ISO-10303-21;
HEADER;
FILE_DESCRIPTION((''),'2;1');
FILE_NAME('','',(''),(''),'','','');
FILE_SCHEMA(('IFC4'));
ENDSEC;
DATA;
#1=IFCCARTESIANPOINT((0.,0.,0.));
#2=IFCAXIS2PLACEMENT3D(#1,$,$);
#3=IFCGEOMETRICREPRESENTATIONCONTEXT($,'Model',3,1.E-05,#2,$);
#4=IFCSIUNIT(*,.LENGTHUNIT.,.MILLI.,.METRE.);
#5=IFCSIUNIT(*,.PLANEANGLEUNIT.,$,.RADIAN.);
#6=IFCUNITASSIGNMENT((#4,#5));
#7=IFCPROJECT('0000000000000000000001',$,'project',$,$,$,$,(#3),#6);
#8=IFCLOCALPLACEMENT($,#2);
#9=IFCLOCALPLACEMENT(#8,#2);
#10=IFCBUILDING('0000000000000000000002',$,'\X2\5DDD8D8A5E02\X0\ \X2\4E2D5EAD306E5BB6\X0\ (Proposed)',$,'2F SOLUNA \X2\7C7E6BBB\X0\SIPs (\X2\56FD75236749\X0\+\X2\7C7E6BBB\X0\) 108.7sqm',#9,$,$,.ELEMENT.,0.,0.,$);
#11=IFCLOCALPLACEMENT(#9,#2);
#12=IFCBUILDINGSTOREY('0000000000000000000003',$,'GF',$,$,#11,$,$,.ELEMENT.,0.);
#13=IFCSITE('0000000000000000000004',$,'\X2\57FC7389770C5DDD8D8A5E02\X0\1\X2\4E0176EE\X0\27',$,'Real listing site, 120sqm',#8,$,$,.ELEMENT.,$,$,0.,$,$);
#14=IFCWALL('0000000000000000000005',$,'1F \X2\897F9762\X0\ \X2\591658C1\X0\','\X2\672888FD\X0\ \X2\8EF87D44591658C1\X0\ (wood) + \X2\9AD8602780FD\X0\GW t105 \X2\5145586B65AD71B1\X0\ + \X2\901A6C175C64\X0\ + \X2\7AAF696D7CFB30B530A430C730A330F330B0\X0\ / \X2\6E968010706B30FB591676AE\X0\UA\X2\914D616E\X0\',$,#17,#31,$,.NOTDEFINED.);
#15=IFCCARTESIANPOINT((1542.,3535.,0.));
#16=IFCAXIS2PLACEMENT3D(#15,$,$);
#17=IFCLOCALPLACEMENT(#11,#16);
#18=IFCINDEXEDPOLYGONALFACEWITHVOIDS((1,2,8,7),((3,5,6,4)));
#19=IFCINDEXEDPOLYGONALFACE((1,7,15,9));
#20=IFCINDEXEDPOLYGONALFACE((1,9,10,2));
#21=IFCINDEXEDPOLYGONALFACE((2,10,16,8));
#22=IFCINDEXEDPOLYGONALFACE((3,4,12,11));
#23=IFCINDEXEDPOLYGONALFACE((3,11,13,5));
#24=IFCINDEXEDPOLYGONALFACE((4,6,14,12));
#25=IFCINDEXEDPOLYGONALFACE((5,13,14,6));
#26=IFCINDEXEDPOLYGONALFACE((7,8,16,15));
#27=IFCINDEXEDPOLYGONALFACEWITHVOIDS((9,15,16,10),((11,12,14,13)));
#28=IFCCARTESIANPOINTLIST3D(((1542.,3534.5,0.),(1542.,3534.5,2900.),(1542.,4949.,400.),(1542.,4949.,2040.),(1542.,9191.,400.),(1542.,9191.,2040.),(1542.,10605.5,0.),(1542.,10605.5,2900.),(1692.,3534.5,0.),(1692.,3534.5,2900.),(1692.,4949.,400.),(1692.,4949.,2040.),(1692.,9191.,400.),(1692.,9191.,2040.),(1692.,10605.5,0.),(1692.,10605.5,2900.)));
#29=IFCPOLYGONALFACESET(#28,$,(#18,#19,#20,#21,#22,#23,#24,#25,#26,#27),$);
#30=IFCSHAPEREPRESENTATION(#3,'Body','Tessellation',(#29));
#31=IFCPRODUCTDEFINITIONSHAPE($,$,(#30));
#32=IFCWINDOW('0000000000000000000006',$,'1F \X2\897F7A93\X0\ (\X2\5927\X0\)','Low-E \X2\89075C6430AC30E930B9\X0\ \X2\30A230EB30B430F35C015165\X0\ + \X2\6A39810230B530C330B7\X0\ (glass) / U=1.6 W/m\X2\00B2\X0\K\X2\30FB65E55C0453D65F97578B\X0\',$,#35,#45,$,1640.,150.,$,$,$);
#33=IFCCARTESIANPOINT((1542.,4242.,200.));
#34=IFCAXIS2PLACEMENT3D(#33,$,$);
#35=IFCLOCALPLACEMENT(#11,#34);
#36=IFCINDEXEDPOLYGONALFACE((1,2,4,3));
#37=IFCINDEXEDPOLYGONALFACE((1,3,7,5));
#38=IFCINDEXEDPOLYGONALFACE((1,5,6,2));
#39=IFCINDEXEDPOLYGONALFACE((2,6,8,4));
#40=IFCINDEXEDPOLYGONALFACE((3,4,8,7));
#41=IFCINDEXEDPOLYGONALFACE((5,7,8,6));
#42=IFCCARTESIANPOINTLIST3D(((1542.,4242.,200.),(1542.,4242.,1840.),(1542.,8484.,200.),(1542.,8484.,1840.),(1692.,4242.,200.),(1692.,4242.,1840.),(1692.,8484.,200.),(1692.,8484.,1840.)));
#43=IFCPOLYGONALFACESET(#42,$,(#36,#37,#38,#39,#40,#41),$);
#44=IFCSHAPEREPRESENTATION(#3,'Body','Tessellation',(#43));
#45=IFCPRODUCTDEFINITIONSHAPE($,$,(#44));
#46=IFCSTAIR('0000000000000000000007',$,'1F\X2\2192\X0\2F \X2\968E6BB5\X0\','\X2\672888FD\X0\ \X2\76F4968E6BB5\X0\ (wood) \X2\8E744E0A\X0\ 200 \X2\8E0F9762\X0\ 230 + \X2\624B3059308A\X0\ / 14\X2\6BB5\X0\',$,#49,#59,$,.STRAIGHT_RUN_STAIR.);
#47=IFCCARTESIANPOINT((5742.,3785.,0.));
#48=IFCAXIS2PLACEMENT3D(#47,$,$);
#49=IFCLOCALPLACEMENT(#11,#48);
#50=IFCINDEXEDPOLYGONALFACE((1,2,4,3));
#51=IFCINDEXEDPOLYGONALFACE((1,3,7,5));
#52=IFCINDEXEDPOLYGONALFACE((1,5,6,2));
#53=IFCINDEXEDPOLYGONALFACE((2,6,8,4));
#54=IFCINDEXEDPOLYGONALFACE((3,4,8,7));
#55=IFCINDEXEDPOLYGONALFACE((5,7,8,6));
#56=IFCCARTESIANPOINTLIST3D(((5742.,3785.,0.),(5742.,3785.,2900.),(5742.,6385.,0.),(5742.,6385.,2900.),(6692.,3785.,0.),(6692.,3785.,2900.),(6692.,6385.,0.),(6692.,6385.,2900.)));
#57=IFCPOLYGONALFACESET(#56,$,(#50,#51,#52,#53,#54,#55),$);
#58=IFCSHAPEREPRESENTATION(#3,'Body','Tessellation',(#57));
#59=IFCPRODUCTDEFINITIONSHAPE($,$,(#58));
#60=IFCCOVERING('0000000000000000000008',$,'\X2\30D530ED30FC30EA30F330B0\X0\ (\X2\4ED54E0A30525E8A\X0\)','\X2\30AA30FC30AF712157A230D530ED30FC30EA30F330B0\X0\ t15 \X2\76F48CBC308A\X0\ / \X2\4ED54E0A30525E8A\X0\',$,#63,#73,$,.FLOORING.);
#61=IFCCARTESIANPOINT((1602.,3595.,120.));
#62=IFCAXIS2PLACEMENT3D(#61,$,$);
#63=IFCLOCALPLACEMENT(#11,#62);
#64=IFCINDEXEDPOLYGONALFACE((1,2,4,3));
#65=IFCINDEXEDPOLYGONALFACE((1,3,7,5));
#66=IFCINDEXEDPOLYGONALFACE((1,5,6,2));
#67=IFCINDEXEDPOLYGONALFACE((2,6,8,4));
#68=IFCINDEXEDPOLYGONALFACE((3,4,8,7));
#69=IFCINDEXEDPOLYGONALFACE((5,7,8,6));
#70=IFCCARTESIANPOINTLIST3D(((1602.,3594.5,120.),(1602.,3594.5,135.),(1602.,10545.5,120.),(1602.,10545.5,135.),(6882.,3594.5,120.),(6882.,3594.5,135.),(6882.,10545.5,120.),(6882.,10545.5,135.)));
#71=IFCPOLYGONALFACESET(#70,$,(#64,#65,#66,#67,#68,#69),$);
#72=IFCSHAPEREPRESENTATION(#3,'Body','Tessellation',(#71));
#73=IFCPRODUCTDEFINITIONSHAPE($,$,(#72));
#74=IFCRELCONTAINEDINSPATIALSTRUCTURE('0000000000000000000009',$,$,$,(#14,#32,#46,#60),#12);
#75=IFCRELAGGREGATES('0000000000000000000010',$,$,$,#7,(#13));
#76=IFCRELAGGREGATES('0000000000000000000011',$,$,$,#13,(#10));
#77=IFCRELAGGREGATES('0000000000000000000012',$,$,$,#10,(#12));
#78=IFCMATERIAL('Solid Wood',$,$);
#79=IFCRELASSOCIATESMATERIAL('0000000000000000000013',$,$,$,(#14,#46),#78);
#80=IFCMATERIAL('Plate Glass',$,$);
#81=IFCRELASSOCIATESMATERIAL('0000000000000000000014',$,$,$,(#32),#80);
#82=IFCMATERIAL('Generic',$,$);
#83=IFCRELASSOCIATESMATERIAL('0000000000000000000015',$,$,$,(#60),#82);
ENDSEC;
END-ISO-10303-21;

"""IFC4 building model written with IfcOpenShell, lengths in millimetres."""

from ifc_helpers import new_model, si_unit, frame, frame_2d, origin, place, context, project, spatial, rectangle, extrude, material, element, fill, save


model = new_model("IFC4")

# Units and contexts
model_context = context("Model", 3, precision=1e-05, world=origin())
ifc_project = project(units=[si_unit("LENGTHUNIT", "METRE", prefix="MILLI"), si_unit("PLANEANGLEUNIT", "RADIAN")], contexts=[model_context])

# Site, building, storey
site_placement = place(None, origin())
site = spatial("IfcSite", under=ifc_project, at=site_placement, Name="埼玉県川越市1丁目27", ObjectType="Real listing site, 120sqm", CompositionType="ELEMENT", RefElevation=0.0)
building_placement = place(site_placement, origin())
building = spatial("IfcBuilding", under=site, at=building_placement, Name="川越市 中庭の家 (Proposed)", ObjectType="2F SOLUNA 籾殻SIPs (国産杉+籾殻) 108.7sqm", CompositionType="ELEMENT", ElevationOfRefHeight=0.0, ElevationOfTerrain=0.0)
storey_placement = place(building_placement, origin())
storey = spatial("IfcBuildingStorey", under=building, at=storey_placement, Name="GF", CompositionType="ELEMENT", Elevation=0.0)

# Shared definitions
ifc_material_1 = material(Name="Solid Wood")
ifc_material_2 = material(Name="Generic")

# Shared definitions
ifc_material_3 = material(Name="Plate Glass")

# Wall, opening, window
wall_1_placement = place(storey_placement, frame((1542.0, 3535.0, 0.0)))
wall_1 = element("IfcWall", 1, at=wall_1_placement, inside=storey, material=ifc_material_1, Name="1F 西面 外壁", Description="木製 軸組外壁 (wood) + 高性能GW t105 充填断熱 + 通気層 + 窯業系サイディング / 準耐火・外皮UA配慮", PredefinedType="NOTDEFINED", context=model_context, shape_type="SweptSolid", body=[
    extrude(rectangle(XDim=150.0, YDim=7071.0, at=frame_2d((75.0, 3535.0))), frame((1542.0, 3535.0, 0.0)), (0.0, 0.0, 1.0), 2900.0),
])
opening_1_placement = place(storey_placement, frame((1542.0, 4242.0, 200.0)))
opening_1 = element("IfcOpeningElement", 2, at=opening_1_placement, cuts=wall_1, PredefinedType="NOTDEFINED", context=model_context, shape_type="SweptSolid", body=[
    extrude(rectangle(XDim=150.0, YDim=4242.0, at=frame_2d((75.0, 2121.0))), frame((1542.0, 4242.0, 200.0)), (0.0, 0.0, 1.0), 1640.0),
])
window_1_placement = place(storey_placement, frame((1542.0, 4242.0, 200.0)))
window_1 = element("IfcWindow", 3, at=window_1_placement, inside=storey, material=ifc_material_3, Name="1F 西窓 (大)", Description="Low-E 複層ガラス アルゴン封入 + 樹脂サッシ (glass) / U=1.6 W/m²K・日射取得型", OverallHeight=1640.0, OverallWidth=150.0, context=model_context, shape_type="SweptSolid", body=[
    extrude(rectangle(XDim=150.0, YDim=4242.0, at=frame_2d((75.0, 2121.0))), frame((1542.0, 4242.0, 200.0)), (0.0, 0.0, 1.0), 1640.0),
])
fill(opening_1, window_1)

# Stair
stair_placement = place(storey_placement, frame((5742.0, 3785.0, 0.0)))
element("IfcStair", 4, at=stair_placement, inside=storey, material=ifc_material_1, Name="1F→2F 階段", Description="木製 直階段 (wood) 蹴上 200 踏面 230 + 手すり / 14段", PredefinedType="STRAIGHT_RUN_STAIR", context=model_context, shape_type="SweptSolid", body=[
    extrude(rectangle(XDim=950.0, YDim=2600.0, at=frame_2d((475.0, 1300.0))), frame((5742.0, 3785.0, 0.0)), (0.0, 0.0, 1.0), 2900.0),
])

# Covering
covering_placement = place(storey_placement, frame((1602.0, 3595.0, 120.0)))
element("IfcCovering", 5, at=covering_placement, inside=storey, material=ifc_material_2, Name="フローリング (仕上げ床)", Description="オーク無垢フローリング t15 直貼り / 仕上げ床", PredefinedType="FLOORING", context=model_context, shape_type="SweptSolid", body=[
    extrude(rectangle(XDim=5280.0, YDim=6951.0, at=frame_2d((2640.0, 3475.0))), frame((1602.0, 3595.0, 120.0)), (0.0, 0.0, 1.0), 15.0),
])

save(model, "model.ifc")
